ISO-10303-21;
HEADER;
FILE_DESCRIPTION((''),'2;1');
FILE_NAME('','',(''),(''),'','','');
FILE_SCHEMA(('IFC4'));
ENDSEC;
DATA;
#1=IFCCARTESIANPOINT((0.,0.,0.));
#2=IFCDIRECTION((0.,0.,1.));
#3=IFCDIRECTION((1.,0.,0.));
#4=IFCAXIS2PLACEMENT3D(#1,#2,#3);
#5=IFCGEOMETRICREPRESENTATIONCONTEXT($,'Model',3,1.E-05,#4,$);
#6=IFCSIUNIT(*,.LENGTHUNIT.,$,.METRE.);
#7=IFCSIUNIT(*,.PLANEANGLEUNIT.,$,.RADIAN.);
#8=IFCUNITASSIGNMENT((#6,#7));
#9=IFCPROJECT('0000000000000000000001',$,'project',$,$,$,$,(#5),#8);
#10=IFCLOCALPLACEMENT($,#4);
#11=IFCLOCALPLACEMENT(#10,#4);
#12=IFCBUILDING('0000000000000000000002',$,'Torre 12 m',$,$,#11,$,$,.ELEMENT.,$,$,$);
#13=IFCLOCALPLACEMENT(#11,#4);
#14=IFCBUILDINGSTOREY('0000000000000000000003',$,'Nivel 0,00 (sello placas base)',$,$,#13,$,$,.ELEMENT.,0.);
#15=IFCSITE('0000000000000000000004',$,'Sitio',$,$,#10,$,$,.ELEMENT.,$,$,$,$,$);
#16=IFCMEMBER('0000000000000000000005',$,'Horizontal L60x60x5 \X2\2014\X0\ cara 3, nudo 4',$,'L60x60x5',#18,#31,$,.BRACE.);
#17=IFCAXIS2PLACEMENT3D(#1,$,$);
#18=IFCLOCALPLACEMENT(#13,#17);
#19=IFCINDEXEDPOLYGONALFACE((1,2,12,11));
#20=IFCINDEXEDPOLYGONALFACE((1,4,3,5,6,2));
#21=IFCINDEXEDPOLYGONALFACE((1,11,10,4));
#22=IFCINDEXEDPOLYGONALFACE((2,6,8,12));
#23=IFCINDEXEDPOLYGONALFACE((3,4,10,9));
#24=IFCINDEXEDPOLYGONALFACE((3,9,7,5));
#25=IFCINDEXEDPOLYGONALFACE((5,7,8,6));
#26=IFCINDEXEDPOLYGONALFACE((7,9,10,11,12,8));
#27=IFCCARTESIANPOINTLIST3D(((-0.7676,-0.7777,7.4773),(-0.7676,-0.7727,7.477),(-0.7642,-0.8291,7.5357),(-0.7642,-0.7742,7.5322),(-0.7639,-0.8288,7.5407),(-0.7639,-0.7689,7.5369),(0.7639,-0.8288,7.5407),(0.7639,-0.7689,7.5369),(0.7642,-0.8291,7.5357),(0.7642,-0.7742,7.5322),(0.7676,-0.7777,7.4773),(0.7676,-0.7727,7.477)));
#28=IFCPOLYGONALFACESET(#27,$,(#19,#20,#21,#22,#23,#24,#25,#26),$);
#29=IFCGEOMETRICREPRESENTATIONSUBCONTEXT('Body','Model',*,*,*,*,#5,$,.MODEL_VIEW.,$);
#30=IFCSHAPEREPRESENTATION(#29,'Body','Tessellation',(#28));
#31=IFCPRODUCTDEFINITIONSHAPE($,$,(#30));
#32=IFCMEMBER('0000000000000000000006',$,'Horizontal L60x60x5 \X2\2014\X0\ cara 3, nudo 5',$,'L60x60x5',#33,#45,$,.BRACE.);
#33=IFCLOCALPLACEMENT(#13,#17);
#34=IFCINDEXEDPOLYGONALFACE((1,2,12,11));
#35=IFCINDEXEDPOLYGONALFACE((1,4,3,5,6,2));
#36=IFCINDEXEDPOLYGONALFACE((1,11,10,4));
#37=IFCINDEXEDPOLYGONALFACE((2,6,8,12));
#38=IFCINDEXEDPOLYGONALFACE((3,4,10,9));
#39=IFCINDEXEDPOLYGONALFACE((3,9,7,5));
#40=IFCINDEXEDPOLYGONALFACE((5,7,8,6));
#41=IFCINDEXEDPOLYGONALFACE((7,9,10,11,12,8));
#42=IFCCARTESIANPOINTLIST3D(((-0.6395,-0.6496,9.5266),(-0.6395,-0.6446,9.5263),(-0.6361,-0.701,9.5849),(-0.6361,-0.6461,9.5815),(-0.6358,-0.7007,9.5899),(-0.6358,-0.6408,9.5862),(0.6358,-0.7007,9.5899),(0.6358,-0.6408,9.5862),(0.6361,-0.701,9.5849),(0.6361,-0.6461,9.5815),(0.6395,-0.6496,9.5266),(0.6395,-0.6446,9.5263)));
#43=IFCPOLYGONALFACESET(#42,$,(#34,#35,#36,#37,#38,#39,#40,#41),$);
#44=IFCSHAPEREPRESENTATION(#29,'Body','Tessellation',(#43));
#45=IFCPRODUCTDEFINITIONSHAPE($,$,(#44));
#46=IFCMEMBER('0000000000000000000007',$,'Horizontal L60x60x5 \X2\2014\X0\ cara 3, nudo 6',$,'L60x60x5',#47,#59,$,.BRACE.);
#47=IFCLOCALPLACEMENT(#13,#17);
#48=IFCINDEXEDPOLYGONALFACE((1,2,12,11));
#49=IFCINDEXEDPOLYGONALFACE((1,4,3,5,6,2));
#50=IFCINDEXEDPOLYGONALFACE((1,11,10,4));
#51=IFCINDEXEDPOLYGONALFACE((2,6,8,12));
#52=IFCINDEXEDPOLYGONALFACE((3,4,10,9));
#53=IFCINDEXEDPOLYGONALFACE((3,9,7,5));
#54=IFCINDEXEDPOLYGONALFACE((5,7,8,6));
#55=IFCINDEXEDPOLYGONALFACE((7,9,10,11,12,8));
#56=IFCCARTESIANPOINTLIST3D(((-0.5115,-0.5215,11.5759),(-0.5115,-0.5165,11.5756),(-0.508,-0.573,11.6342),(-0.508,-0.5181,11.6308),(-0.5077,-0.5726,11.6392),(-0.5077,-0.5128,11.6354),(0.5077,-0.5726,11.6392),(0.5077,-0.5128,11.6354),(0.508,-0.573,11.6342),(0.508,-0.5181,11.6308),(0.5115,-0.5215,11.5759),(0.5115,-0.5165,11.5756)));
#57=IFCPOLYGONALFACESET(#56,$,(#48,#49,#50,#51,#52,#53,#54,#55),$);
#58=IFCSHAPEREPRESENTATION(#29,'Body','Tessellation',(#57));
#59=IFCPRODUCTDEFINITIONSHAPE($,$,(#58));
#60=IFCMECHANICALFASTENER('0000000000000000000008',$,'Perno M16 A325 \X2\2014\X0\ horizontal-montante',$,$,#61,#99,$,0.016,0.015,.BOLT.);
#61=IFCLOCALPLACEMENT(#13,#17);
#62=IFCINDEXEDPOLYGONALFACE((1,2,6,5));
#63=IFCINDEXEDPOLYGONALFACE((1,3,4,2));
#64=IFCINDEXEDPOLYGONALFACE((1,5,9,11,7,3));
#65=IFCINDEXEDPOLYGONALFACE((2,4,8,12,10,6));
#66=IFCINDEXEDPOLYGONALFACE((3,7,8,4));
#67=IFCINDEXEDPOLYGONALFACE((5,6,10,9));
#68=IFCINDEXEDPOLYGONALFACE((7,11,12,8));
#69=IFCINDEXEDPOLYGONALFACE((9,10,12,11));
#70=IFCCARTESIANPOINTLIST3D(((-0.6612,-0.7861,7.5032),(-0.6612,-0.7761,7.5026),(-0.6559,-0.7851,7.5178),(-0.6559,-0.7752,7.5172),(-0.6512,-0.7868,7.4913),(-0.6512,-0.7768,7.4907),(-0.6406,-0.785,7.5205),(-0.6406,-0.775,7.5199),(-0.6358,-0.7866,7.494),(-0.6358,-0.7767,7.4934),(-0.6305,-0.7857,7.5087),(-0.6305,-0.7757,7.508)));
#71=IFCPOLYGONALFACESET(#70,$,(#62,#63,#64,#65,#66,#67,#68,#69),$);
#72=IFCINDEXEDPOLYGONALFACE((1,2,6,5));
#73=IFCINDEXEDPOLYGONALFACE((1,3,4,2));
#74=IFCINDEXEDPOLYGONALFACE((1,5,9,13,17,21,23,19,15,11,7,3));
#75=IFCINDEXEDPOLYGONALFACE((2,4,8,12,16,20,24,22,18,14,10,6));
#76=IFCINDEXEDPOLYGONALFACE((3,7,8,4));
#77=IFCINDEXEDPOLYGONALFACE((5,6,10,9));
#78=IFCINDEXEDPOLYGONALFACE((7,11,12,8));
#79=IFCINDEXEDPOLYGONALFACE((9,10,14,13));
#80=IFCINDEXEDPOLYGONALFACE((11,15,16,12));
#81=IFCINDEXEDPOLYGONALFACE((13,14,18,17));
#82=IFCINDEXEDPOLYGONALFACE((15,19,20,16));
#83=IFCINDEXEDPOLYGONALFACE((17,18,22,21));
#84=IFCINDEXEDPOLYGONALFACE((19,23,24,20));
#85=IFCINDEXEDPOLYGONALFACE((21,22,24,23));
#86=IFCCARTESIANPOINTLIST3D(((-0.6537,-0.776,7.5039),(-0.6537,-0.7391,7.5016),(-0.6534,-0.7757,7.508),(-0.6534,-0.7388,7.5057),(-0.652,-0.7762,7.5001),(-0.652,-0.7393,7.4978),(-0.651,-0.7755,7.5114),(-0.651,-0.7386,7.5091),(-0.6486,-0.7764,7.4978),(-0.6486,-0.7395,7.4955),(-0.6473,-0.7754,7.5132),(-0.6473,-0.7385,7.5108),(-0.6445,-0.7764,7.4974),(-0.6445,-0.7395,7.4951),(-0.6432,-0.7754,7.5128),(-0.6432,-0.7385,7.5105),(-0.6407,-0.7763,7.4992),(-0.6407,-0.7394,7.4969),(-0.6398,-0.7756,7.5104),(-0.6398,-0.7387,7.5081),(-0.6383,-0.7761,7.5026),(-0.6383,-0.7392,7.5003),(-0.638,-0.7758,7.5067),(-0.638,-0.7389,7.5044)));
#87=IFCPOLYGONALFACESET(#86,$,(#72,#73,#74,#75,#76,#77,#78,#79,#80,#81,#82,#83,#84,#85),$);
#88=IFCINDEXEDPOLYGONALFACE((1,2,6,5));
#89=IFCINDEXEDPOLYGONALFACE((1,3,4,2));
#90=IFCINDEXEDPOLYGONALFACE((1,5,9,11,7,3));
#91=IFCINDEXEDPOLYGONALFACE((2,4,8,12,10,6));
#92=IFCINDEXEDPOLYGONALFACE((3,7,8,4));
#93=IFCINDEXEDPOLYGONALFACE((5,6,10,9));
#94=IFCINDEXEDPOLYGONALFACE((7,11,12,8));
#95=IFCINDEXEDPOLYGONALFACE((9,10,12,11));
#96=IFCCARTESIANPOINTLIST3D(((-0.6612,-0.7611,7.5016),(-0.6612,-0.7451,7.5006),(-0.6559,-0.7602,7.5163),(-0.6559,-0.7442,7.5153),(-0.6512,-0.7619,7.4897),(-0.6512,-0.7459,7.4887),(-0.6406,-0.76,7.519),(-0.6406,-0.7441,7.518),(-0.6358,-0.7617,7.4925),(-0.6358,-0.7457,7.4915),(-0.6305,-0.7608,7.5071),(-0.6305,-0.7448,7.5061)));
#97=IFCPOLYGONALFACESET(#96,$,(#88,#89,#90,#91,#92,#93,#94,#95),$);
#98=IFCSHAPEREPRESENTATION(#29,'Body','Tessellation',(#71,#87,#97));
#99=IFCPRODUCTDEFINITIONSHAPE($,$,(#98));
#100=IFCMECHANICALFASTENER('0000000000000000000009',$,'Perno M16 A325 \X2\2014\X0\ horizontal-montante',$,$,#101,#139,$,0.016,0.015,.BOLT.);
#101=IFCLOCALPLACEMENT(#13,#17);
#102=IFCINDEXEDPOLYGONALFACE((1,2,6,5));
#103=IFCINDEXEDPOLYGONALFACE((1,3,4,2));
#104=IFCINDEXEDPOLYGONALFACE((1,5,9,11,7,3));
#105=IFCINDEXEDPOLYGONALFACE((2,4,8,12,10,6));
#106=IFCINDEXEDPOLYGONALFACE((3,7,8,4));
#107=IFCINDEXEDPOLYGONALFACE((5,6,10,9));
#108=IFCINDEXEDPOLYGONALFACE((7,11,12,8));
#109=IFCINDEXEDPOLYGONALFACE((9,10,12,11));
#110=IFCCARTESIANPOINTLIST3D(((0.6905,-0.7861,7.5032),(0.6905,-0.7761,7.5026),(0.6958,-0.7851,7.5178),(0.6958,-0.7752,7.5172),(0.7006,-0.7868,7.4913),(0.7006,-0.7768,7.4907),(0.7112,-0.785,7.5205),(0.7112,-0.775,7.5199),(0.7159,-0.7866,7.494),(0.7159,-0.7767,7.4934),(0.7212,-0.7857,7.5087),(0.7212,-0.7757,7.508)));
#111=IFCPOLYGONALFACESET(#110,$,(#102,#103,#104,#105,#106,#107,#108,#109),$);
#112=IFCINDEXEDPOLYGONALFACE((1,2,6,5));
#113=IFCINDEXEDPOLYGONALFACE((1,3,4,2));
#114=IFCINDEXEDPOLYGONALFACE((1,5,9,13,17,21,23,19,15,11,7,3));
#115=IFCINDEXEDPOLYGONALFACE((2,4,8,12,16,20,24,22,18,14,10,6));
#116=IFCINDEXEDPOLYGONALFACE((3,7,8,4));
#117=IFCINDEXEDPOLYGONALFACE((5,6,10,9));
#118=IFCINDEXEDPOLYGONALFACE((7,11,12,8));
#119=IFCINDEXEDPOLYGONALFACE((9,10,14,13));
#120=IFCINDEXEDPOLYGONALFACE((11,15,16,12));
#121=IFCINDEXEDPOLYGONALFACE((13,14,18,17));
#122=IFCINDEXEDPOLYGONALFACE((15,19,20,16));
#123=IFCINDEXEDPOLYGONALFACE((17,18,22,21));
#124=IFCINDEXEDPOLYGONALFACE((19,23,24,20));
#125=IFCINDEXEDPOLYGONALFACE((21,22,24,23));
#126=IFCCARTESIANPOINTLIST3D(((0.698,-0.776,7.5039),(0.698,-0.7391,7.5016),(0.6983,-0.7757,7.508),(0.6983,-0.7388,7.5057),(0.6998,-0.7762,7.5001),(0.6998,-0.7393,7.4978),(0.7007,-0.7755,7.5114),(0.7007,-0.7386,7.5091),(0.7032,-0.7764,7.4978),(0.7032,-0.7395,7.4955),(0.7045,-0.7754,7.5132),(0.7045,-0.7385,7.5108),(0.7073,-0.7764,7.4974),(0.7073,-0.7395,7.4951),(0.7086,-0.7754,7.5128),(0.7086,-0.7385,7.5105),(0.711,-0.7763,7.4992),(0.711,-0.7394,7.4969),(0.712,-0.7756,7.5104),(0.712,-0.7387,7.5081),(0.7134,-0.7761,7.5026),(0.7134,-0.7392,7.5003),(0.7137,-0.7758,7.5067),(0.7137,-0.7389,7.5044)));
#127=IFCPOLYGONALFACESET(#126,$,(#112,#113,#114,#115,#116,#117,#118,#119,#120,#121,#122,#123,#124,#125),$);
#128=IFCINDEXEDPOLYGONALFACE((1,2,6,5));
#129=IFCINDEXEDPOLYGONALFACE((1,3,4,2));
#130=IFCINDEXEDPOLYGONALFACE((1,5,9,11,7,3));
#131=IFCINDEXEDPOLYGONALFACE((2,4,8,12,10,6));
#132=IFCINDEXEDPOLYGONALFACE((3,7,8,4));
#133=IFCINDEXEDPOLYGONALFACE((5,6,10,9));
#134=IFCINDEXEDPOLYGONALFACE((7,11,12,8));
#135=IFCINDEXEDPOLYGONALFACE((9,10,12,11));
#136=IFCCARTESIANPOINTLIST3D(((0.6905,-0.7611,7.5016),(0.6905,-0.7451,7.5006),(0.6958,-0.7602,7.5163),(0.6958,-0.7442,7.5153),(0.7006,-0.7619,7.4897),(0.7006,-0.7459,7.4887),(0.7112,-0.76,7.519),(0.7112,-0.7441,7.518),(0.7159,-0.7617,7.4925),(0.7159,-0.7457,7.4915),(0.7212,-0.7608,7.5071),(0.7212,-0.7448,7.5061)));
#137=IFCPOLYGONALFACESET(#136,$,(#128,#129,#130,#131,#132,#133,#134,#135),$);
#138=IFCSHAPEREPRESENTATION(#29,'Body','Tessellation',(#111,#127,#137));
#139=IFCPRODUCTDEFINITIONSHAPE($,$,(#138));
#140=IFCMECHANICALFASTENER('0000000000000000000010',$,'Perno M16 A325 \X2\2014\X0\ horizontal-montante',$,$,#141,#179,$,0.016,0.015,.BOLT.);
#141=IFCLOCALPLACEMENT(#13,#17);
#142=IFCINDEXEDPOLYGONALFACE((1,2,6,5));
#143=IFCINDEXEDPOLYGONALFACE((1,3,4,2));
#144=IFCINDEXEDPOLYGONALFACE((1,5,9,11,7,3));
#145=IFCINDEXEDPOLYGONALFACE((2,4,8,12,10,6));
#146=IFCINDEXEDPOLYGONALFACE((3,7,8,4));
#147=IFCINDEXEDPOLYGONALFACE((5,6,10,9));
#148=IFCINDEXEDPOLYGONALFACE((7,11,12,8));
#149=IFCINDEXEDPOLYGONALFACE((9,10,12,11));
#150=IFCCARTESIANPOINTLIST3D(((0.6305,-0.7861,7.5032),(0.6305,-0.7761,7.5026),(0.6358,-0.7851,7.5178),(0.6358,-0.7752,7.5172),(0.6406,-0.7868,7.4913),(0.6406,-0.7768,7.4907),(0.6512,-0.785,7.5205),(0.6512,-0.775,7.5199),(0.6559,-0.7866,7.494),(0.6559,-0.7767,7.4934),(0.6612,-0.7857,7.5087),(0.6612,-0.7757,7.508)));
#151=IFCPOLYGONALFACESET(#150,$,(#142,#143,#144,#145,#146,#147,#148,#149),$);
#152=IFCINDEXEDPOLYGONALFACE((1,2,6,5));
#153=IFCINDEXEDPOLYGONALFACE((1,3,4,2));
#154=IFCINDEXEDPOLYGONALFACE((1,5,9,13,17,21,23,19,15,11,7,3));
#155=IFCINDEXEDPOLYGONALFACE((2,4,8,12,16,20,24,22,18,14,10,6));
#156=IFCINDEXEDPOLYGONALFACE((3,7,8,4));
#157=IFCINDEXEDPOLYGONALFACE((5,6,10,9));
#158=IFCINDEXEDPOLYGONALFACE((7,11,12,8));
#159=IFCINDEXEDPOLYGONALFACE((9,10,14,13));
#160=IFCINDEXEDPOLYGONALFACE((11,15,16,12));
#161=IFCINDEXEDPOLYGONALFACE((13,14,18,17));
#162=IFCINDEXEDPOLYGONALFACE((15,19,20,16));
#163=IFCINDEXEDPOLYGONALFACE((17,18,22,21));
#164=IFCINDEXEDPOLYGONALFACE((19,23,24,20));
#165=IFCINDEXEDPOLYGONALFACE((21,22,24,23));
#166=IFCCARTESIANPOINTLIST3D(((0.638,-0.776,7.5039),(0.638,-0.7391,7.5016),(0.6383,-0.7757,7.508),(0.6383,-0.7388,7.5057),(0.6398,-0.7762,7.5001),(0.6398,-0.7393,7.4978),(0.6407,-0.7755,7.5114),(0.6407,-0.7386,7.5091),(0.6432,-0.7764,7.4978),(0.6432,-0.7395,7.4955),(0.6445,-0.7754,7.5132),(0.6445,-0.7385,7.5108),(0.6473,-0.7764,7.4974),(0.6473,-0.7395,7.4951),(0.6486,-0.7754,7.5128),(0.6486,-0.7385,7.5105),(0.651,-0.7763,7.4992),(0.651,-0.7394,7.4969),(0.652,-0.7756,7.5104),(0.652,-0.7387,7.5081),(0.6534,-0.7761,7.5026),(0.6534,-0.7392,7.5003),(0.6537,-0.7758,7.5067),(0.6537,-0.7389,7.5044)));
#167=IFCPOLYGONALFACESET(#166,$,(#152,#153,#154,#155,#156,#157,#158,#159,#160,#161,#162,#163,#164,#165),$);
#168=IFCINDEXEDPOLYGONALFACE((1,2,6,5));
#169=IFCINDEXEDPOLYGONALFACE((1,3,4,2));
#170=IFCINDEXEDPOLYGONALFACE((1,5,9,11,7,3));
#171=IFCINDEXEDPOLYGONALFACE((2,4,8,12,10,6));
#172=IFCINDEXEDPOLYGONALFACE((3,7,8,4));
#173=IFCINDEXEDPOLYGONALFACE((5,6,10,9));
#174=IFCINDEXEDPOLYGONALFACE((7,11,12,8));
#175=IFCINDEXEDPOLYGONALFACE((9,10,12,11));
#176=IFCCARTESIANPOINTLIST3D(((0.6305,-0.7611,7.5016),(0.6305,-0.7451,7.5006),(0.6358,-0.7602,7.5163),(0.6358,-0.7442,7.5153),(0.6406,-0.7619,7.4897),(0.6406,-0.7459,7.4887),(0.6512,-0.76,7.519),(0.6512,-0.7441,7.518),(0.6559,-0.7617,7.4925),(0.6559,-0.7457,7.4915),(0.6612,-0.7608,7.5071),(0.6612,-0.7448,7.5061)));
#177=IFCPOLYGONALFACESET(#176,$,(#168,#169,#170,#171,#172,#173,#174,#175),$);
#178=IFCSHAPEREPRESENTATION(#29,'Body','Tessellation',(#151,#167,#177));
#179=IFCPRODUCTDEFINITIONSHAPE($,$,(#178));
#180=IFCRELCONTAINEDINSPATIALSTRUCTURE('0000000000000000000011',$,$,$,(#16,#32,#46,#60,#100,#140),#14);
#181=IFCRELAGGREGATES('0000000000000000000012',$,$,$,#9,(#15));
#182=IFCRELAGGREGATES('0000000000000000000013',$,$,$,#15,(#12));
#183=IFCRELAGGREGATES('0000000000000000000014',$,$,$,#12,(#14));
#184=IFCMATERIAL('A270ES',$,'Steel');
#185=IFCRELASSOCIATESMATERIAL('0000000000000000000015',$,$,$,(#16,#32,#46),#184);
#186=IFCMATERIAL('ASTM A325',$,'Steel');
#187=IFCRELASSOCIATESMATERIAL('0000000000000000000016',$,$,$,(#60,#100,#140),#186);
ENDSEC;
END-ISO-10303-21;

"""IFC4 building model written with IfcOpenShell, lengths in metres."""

from ifc_helpers import new_model, si_unit, frame, origin_with_axes, place, context, subcontext, project, spatial, polyline, outline, extrude, clip, halfspace, material, element, save


model = new_model("IFC4")

# Units and contexts
model_context = context("Model", 3, precision=1e-05, world=origin_with_axes())
body_context = subcontext(model_context, "Body", "Model", "MODEL_VIEW")
ifc_project = project(units=[si_unit("LENGTHUNIT", "METRE"), si_unit("PLANEANGLEUNIT", "RADIAN")], contexts=[model_context])

# Site, building, storey
site_placement = place(None, origin_with_axes())
site = spatial("IfcSite", under=ifc_project, at=site_placement, Name="Sitio", CompositionType="ELEMENT")
building_placement = place(site_placement, origin_with_axes())
building = spatial("IfcBuilding", under=site, at=building_placement, Name="Torre 12 m", CompositionType="ELEMENT")
storey_placement = place(building_placement, origin_with_axes())
storey = spatial("IfcBuildingStorey", under=building, at=storey_placement, Name="Nivel 0,00 (sello placas base)", CompositionType="ELEMENT", Elevation=0.0)

# Members
ifc_material_1 = material(Name="A270ES", Category="Steel")
placement = place(storey_placement, origin_with_axes())
element("IfcMember", 1, at=placement, inside=storey, material=ifc_material_1, Name="Horizontal L60x60x5 — cara 3, nudo 4", ObjectType="L60x60x5", PredefinedType="BRACE", context=body_context, shape_type="Clipping", body=[
    clip(clip(extrude(outline(polyline([(0.0, -0.06), (0.005, -0.06), (0.005, -0.005), (0.06, -0.005), (0.06, 0.0), (0.0, 0.0), (0.0, -0.06)])), frame((-0.8259, -0.7689, 7.5369), z_axis=(1.0, 0.0, 0.0), x_axis=(0.0, -0.062378, -0.998053)), (0.0, 0.0, 1.0), 1.6517), halfspace(frame((-0.7659, -0.7709, 7.5047), z_axis=(0.99806, -0.003884, -0.062136), x_axis=(0.029174, -0.852518, 0.521883)), True)), halfspace(frame((0.7659, -0.7709, 7.5047), z_axis=(-0.99806, -0.003884, -0.062136), x_axis=(0.030208, 0.842481, -0.537879)), True)),
])
element("IfcMember", 2, at=placement, inside=storey, material=ifc_material_1, Name="Horizontal L60x60x5 — cara 3, nudo 5", ObjectType="L60x60x5", PredefinedType="BRACE", context=body_context, shape_type="Clipping", body=[
    clip(clip(extrude(outline(polyline([(0.0, -0.06), (0.005, -0.06), (0.005, -0.005), (0.06, -0.005), (0.06, 0.0), (0.0, 0.0), (0.0, -0.06)])), frame((-0.6978, -0.6408, 9.5862), z_axis=(1.0, 0.0, 0.0), x_axis=(0.0, -0.062378, -0.998053)), (0.0, 0.0, 1.0), 1.3956), halfspace(frame((-0.6378, -0.6429, 9.5539), z_axis=(0.99806, -0.003884, -0.062136), x_axis=(0.029174, -0.852518, 0.521883)), True)), halfspace(frame((0.6378, -0.6429, 9.5539), z_axis=(-0.99806, -0.003884, -0.062136), x_axis=(0.030208, 0.842481, -0.537879)), True)),
])
element("IfcMember", 3, at=placement, inside=storey, material=ifc_material_1, Name="Horizontal L60x60x5 — cara 3, nudo 6", ObjectType="L60x60x5", PredefinedType="BRACE", context=body_context, shape_type="Clipping", body=[
    clip(clip(extrude(outline(polyline([(0.0, -0.06), (0.005, -0.06), (0.005, -0.005), (0.06, -0.005), (0.06, 0.0), (0.0, 0.0), (0.0, -0.06)])), frame((-0.5697, -0.5128, 11.6355), z_axis=(1.0, 0.0, 0.0), x_axis=(0.0, -0.062378, -0.998053)), (0.0, 0.0, 1.0), 1.1394), halfspace(frame((-0.5097, -0.5148, 11.6032), z_axis=(0.99806, -0.003884, -0.062136), x_axis=(0.029174, -0.852518, 0.521883)), True)), halfspace(frame((0.5097, -0.5148, 11.6032), z_axis=(-0.99806, -0.003884, -0.062136), x_axis=(0.030208, 0.842481, -0.537879)), True)),
])

# Mechanical fasteners
ifc_material_2 = material(Name="ASTM A325", Category="Steel")
element("IfcMechanicalFastener", 4, at=placement, inside=storey, material=ifc_material_2, Name="Perno M16 A325 — horizontal-montante", NominalDiameter=0.016, NominalLength=0.015, PredefinedType="BOLT", context=body_context, shape_type="SweptSolid", body=[
    extrude(outline(polyline([(0.0135, 0.0078), (0.0, 0.0156), (-0.0135, 0.0078), (-0.0135, -0.0078), (0.0, -0.0156), (0.0135, -0.0078), (0.0135, 0.0078)])), frame((-0.6459, -0.7859, 7.5059), z_axis=(0.0, 0.998053, -0.062378), x_axis=(0.940405, -0.021212, -0.339394)), (0.0, 0.0, 1.0), 0.01),
    extrude(outline(polyline([(0.008, 0.0), (0.0069, 0.004), (0.004, 0.0069), (0.0, 0.008), (-0.004, 0.0069), (-0.0069, 0.004), (-0.008, 0.0), (-0.0069, -0.004), (-0.004, -0.0069), (0.0, -0.008), (0.004, -0.0069), (0.0069, -0.004), (0.008, 0.0)])), frame((-0.6459, -0.7759, 7.5053), z_axis=(0.0, 0.998053, -0.062378), x_axis=(0.940405, -0.021212, -0.339394)), (0.0, 0.0, 1.0), 0.037),
    extrude(outline(polyline([(0.0135, 0.0078), (0.0, 0.0156), (-0.0135, 0.0078), (-0.0135, -0.0078), (0.0, -0.0156), (0.0135, -0.0078), (0.0135, 0.0078)])), frame((-0.6459, -0.7609, 7.5044), z_axis=(0.0, 0.998053, -0.062378), x_axis=(0.940405, -0.021212, -0.339394)), (0.0, 0.0, 1.0), 0.016),
])
element("IfcMechanicalFastener", 5, at=placement, inside=storey, material=ifc_material_2, Name="Perno M16 A325 — horizontal-montante", NominalDiameter=0.016, NominalLength=0.015, PredefinedType="BOLT", context=body_context, shape_type="SweptSolid", body=[
    extrude(outline(polyline([(0.0135, 0.0078), (0.0, 0.0156), (-0.0135, 0.0078), (-0.0135, -0.0078), (0.0, -0.0156), (0.0135, -0.0078), (0.0135, 0.0078)])), frame((0.7059, -0.7859, 7.5059), z_axis=(0.0, 0.998053, -0.062378), x_axis=(0.940405, -0.021212, -0.339394)), (0.0, 0.0, 1.0), 0.01),
    extrude(outline(polyline([(0.008, 0.0), (0.0069, 0.004), (0.004, 0.0069), (0.0, 0.008), (-0.004, 0.0069), (-0.0069, 0.004), (-0.008, 0.0), (-0.0069, -0.004), (-0.004, -0.0069), (0.0, -0.008), (0.004, -0.0069), (0.0069, -0.004), (0.008, 0.0)])), frame((0.7059, -0.7759, 7.5053), z_axis=(0.0, 0.998053, -0.062378), x_axis=(0.940405, -0.021212, -0.339394)), (0.0, 0.0, 1.0), 0.037),
    extrude(outline(polyline([(0.0135, 0.0078), (0.0, 0.0156), (-0.0135, 0.0078), (-0.0135, -0.0078), (0.0, -0.0156), (0.0135, -0.0078), (0.0135, 0.0078)])), frame((0.7059, -0.7609, 7.5044), z_axis=(0.0, 0.998053, -0.062378), x_axis=(0.940405, -0.021212, -0.339394)), (0.0, 0.0, 1.0), 0.016),
])
element("IfcMechanicalFastener", 6, at=placement, inside=storey, material=ifc_material_2, Name="Perno M16 A325 — horizontal-montante", NominalDiameter=0.016, NominalLength=0.015, PredefinedType="BOLT", context=body_context, shape_type="SweptSolid", body=[
    extrude(outline(polyline([(0.0135, 0.0078), (0.0, 0.0156), (-0.0135, 0.0078), (-0.0135, -0.0078), (0.0, -0.0156), (0.0135, -0.0078), (0.0135, 0.0078)])), frame((0.6459, -0.7859, 7.5059), z_axis=(0.0, 0.998053, -0.062378), x_axis=(0.940405, -0.021212, -0.339394)), (0.0, 0.0, 1.0), 0.01),
    extrude(outline(polyline([(0.008, 0.0), (0.0069, 0.004), (0.004, 0.0069), (0.0, 0.008), (-0.004, 0.0069), (-0.0069, 0.004), (-0.008, 0.0), (-0.0069, -0.004), (-0.004, -0.0069), (0.0, -0.008), (0.004, -0.0069), (0.0069, -0.004), (0.008, 0.0)])), frame((0.6459, -0.7759, 7.5053), z_axis=(0.0, 0.998053, -0.062378), x_axis=(0.940405, -0.021212, -0.339394)), (0.0, 0.0, 1.0), 0.037),
    extrude(outline(polyline([(0.0135, 0.0078), (0.0, 0.0156), (-0.0135, 0.0078), (-0.0135, -0.0078), (0.0, -0.0156), (0.0135, -0.0078), (0.0135, 0.0078)])), frame((0.6459, -0.7609, 7.5044), z_axis=(0.0, 0.998053, -0.062378), x_axis=(0.940405, -0.021212, -0.339394)), (0.0, 0.0, 1.0), 0.016),
])

save(model, "model.ifc")
